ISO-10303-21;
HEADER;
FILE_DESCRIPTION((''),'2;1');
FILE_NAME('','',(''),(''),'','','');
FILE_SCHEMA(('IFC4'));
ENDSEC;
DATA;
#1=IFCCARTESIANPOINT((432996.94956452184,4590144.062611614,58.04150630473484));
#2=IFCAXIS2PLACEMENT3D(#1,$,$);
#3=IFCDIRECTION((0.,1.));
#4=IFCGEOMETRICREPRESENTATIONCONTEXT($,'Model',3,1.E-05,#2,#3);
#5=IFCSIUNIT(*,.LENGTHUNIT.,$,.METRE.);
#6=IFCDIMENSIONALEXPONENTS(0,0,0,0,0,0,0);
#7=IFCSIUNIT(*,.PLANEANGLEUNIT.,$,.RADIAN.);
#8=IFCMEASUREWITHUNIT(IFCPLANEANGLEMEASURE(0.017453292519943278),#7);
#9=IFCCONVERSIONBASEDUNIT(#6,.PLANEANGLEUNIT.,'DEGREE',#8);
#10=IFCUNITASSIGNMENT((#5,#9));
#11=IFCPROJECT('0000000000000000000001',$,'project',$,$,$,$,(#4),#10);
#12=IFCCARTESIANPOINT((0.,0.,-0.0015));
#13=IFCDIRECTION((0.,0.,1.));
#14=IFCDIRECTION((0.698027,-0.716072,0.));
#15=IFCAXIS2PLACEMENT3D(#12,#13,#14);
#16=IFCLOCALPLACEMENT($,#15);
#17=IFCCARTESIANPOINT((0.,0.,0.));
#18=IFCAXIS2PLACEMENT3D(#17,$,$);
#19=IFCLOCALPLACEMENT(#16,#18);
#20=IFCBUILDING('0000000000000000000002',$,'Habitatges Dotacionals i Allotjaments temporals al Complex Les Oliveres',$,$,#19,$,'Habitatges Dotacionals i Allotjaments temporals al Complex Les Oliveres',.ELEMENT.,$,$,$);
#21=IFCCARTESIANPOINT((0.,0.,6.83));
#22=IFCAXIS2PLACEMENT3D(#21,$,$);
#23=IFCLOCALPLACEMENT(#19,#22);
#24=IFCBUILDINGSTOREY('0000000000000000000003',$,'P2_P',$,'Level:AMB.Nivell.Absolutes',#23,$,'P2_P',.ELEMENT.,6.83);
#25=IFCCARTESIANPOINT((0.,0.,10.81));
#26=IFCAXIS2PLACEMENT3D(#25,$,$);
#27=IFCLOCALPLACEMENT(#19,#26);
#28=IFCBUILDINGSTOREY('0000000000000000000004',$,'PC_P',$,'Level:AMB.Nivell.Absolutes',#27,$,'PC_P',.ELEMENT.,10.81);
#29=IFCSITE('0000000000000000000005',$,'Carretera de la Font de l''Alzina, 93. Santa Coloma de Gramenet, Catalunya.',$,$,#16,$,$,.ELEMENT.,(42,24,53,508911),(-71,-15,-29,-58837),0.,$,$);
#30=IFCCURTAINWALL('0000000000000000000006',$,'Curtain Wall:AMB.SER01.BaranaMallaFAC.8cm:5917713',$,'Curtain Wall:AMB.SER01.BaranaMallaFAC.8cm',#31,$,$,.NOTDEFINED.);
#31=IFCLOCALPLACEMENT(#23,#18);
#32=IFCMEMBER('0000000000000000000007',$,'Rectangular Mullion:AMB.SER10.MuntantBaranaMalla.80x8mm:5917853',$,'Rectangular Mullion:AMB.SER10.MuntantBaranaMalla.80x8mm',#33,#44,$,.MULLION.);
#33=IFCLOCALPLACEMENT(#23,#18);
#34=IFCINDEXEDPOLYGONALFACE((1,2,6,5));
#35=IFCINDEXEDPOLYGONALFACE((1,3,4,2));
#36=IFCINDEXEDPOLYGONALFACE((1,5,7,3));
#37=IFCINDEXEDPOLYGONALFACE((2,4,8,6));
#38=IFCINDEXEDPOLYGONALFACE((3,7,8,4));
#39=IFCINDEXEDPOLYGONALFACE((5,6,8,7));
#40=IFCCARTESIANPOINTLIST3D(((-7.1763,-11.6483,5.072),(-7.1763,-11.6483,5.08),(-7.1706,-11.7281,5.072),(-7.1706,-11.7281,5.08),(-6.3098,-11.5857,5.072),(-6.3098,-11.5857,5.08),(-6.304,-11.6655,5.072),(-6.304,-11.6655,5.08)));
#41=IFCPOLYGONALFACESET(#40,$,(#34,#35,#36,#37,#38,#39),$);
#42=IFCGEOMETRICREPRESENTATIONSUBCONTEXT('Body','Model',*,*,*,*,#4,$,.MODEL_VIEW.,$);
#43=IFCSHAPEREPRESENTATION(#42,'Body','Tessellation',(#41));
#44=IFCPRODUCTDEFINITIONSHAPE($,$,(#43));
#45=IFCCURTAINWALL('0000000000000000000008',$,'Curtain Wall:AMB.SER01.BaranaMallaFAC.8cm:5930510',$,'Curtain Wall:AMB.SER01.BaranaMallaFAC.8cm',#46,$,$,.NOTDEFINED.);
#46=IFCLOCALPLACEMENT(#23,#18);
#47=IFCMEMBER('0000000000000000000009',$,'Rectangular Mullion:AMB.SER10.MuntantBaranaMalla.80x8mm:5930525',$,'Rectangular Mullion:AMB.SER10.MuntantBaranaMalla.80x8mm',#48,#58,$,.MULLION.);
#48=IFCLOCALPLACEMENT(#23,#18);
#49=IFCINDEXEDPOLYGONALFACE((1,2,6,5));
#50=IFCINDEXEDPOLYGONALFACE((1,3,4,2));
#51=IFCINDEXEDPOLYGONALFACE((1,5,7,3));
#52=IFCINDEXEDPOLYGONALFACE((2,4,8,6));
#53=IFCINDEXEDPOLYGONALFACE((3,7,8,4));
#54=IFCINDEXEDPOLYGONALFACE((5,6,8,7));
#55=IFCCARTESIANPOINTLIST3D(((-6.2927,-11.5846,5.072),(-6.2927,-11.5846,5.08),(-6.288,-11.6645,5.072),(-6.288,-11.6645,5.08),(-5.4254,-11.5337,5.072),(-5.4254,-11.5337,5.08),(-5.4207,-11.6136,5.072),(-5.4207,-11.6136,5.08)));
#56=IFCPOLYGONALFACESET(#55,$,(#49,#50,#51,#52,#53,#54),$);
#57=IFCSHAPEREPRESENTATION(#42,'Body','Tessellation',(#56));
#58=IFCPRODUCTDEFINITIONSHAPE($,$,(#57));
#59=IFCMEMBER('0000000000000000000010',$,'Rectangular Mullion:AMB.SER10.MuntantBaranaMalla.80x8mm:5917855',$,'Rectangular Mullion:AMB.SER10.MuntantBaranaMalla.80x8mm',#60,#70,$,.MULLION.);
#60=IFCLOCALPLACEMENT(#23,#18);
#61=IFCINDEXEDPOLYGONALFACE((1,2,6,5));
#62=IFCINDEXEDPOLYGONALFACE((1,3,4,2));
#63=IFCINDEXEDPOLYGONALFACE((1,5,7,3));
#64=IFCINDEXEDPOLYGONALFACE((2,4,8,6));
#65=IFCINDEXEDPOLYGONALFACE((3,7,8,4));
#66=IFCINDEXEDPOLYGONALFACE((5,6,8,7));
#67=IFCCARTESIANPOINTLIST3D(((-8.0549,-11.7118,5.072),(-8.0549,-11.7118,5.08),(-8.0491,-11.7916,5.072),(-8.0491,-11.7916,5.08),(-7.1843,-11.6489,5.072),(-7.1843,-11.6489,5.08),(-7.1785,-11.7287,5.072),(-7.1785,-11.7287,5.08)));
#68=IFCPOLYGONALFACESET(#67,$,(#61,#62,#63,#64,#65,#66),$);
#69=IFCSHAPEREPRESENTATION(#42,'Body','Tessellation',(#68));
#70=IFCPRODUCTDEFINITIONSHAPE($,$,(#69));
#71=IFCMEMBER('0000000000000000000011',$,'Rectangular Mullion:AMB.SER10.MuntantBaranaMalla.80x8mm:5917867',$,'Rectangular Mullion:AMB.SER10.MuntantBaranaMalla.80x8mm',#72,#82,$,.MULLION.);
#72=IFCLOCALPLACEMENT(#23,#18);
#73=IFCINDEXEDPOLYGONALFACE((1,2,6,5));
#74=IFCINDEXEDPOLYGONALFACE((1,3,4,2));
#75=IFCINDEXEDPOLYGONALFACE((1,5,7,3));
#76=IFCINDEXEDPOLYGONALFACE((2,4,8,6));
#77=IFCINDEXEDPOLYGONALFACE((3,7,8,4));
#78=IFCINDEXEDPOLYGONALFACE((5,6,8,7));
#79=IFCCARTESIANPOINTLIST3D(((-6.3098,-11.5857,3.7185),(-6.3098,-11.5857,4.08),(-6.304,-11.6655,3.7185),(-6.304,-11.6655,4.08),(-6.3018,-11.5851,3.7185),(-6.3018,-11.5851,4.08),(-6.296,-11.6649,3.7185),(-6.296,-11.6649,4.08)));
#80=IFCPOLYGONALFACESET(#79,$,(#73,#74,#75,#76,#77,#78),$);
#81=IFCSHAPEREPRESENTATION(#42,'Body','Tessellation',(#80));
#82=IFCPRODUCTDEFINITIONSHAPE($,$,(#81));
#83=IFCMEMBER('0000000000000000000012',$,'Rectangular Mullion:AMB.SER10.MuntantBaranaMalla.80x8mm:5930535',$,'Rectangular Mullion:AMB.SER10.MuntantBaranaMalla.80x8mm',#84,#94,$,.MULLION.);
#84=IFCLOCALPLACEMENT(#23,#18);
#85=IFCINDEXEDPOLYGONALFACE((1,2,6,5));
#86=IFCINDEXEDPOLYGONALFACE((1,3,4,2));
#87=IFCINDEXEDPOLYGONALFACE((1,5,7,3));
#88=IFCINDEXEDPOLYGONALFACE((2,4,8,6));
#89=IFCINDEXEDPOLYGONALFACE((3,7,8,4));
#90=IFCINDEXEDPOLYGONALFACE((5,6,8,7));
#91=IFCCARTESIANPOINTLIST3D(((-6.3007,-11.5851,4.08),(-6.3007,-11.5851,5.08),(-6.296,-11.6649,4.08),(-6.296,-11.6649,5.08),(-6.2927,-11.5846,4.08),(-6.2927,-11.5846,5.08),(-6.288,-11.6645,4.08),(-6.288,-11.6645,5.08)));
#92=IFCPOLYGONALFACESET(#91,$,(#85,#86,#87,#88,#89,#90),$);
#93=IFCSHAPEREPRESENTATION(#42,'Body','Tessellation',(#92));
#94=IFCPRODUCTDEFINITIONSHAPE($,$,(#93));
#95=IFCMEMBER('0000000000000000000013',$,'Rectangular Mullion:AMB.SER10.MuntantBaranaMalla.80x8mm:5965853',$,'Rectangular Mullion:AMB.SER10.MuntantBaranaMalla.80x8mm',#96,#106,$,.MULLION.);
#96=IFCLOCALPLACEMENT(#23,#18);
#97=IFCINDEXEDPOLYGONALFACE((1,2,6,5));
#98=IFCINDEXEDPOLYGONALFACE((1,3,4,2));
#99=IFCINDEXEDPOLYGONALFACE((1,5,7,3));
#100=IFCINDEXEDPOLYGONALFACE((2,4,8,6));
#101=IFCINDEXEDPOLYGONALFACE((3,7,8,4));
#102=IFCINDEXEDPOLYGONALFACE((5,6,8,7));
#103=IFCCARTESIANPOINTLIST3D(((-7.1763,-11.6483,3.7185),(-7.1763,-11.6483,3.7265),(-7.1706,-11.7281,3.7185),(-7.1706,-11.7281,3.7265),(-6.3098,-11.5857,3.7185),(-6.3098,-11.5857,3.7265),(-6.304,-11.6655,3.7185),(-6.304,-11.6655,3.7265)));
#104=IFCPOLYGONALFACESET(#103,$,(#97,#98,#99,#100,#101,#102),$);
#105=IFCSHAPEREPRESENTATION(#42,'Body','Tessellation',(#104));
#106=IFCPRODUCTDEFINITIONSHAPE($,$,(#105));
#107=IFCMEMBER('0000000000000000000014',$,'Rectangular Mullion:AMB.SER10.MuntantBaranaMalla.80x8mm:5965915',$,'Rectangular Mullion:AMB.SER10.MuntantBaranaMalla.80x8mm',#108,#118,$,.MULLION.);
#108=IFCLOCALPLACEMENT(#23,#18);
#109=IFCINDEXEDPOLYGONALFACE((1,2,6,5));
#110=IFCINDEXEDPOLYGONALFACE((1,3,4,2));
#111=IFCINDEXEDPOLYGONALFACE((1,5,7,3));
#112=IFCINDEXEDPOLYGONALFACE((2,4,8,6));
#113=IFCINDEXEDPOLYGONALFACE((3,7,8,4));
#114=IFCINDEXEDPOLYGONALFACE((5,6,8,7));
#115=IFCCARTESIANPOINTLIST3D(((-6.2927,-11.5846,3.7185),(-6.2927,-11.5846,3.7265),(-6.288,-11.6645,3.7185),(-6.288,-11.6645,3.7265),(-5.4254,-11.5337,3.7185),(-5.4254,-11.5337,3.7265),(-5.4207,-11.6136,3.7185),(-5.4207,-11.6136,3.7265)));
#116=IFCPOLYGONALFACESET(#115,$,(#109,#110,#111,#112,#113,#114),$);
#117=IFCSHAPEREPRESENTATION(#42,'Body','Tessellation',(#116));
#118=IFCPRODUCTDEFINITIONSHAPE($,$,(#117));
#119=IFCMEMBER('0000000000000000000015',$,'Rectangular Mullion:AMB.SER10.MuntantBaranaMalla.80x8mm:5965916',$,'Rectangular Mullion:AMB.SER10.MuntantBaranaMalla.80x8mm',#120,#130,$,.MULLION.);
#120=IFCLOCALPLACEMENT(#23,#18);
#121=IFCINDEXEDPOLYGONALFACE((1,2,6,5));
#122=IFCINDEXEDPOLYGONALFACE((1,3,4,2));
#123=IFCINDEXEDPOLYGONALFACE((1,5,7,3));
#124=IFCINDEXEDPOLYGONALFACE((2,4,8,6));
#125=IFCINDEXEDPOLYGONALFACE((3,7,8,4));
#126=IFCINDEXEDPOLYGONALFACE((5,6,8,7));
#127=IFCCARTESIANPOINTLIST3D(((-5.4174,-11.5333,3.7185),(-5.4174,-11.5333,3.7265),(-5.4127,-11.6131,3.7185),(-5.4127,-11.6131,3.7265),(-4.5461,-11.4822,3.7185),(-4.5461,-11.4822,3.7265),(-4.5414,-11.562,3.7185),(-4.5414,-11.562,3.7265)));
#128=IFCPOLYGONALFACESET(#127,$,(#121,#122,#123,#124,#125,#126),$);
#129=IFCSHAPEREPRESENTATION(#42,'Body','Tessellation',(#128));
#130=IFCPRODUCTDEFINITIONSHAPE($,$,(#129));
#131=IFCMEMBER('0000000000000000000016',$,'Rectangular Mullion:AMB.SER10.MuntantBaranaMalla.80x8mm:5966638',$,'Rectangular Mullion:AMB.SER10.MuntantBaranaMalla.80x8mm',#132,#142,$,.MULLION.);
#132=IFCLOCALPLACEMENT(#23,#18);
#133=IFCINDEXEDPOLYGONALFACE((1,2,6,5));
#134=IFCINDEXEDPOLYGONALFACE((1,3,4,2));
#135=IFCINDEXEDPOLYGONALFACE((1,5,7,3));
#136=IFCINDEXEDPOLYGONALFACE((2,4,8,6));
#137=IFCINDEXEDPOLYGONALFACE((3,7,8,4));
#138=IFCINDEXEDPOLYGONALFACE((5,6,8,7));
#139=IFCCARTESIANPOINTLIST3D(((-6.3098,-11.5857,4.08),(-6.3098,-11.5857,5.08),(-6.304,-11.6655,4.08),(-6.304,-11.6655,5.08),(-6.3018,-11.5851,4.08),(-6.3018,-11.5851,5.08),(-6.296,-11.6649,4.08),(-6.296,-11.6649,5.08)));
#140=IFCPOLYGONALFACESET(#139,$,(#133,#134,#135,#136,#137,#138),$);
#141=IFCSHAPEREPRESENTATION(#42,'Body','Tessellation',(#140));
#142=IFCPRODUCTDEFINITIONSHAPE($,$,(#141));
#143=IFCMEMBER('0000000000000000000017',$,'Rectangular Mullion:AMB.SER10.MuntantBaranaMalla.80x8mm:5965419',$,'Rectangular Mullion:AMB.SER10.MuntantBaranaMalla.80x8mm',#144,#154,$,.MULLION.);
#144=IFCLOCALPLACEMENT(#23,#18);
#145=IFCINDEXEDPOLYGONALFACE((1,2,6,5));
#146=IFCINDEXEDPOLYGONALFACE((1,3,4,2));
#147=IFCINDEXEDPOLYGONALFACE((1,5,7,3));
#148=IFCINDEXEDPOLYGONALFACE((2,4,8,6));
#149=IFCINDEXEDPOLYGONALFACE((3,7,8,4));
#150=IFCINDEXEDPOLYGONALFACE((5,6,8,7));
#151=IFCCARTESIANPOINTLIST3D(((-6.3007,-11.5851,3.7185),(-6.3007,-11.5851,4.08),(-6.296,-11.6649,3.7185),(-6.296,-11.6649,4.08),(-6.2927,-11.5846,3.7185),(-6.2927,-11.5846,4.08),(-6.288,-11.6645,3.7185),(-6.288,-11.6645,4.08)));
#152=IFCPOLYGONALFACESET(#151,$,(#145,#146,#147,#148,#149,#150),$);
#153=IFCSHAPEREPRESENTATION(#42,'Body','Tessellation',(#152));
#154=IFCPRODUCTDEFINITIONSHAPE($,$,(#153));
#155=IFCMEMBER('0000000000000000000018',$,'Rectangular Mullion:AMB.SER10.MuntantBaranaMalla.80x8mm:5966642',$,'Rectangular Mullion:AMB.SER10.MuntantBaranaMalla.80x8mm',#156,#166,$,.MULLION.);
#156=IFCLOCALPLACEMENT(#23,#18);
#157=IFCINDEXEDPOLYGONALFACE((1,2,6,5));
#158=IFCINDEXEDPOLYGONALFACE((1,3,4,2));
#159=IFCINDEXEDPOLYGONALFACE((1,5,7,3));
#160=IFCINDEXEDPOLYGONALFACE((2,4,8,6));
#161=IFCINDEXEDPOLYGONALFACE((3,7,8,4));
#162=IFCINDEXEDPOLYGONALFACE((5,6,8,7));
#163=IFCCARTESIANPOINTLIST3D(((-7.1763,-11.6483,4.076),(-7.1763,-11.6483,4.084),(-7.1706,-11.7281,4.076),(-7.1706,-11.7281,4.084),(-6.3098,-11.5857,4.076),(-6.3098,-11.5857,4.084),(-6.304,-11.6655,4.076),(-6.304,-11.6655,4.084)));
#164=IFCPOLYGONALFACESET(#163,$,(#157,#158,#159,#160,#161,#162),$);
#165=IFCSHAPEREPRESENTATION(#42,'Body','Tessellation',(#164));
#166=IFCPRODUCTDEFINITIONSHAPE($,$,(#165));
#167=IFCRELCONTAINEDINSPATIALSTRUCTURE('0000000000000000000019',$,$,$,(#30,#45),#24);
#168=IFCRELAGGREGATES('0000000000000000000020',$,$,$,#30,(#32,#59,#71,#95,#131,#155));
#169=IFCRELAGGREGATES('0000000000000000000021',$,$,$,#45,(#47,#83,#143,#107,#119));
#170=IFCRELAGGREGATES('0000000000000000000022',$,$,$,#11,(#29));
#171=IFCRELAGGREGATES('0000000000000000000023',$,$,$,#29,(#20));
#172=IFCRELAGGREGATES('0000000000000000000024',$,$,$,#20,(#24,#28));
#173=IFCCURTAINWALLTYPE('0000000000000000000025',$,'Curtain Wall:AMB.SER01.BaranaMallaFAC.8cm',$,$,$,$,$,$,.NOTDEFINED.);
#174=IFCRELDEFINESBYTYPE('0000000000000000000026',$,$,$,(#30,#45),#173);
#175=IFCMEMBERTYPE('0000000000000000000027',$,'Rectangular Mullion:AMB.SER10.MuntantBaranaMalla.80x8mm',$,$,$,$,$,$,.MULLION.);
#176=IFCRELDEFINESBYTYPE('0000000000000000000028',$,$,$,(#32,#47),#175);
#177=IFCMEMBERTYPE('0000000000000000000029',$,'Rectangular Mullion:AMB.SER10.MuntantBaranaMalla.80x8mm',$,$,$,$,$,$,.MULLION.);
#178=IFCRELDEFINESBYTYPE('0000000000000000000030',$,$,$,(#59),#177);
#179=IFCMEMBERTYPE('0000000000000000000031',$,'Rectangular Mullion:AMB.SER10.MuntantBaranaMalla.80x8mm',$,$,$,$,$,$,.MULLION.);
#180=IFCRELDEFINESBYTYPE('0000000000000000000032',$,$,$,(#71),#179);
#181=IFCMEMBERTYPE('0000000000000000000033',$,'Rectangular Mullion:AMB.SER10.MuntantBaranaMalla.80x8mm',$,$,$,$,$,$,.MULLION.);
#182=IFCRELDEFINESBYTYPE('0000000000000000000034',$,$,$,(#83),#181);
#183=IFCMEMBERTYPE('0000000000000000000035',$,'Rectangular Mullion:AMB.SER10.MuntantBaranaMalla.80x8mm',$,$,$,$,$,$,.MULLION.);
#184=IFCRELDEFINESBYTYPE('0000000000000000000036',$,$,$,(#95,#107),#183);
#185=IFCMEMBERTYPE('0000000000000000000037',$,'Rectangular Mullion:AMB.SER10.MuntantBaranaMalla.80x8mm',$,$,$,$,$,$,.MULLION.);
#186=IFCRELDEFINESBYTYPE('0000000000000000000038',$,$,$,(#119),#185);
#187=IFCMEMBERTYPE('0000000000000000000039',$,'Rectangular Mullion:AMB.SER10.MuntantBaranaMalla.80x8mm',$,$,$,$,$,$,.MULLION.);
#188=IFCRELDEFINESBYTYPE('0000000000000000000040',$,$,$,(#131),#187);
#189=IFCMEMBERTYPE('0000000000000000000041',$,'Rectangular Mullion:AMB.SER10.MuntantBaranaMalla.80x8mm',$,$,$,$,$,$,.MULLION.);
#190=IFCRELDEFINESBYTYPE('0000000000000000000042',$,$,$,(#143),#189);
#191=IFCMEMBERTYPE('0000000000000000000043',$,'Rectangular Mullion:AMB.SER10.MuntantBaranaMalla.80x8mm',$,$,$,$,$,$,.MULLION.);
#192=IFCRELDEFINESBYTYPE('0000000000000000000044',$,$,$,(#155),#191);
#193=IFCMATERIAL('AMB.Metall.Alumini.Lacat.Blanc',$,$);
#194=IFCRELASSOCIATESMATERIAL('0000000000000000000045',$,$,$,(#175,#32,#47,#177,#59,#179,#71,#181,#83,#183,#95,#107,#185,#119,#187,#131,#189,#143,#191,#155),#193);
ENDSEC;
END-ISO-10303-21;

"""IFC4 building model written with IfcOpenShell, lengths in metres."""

from ifc_helpers import new_model, entity, si_unit, converted_unit, direction, frame, origin, place, context, subcontext, project, spatial, indexed_curve, outline, extrude, source, transform, mapped, material, type_object, type_shapes, element, aggregate, save


model = new_model("IFC4")

# Units and contexts
model_context = context("Model", 3, precision=1e-05, world=frame((432996.94956452184, 4590144.062611614, 58.04150630473484)), true_north=direction((0.0, 1.0)))
body_context = subcontext(model_context, "Body", "Model", "MODEL_VIEW")
ifc_project = project(units=[si_unit("LENGTHUNIT", "METRE"), converted_unit("PLANEANGLEUNIT", "DEGREE", entity("IfcPlaneAngleMeasure", 0.017453292519943278), si_unit("PLANEANGLEUNIT", "RADIAN"), dimensions=[0, 0, 0, 0, 0, 0, 0])], contexts=[model_context])

# Site, building, storey
site_placement = place(None, frame((0.0, 0.0, -0.0015), z_axis=(0.0, 0.0, 1.0), x_axis=(0.698027, -0.716072, 0.0)))
site = spatial("IfcSite", under=ifc_project, at=site_placement, Name="Carretera de la Font de l'Alzina, 93. Santa Coloma de Gramenet, Catalunya.", CompositionType="ELEMENT", RefLatitude=(42, 24, 53, 508911), RefLongitude=(-71, -15, -29, -58837), RefElevation=0.0)
building_placement = place(site_placement, origin())
building = spatial("IfcBuilding", under=site, at=building_placement, Name="Habitatges Dotacionals i Allotjaments temporals al Complex Les Oliveres", LongName="Habitatges Dotacionals i Allotjaments temporals al Complex Les Oliveres", CompositionType="ELEMENT")
storey_1_placement = place(building_placement, frame((0.0, 0.0, 6.83)))
storey_1 = spatial("IfcBuildingStorey", under=building, at=storey_1_placement, Name="P2_P", ObjectType="Level:AMB.Nivell.Absolutes", LongName="P2_P", CompositionType="ELEMENT", Elevation=6.83)

# Curtain walls, members
curtain_wall_type = type_object("IfcCurtainWallType", Name="Curtain Wall:AMB.SER01.BaranaMallaFAC.8cm", PredefinedType="NOTDEFINED")
curtain_wall_1_placement = place(storey_1_placement, frame((0.0, 0.0, -6.83)))
curtain_wall_1 = element("IfcCurtainWall", 1, at=curtain_wall_1_placement, inside=storey_1, type_object=curtain_wall_type, Name="Curtain Wall:AMB.SER01.BaranaMallaFAC.8cm:5917713", ObjectType="Curtain Wall:AMB.SER01.BaranaMallaFAC.8cm", PredefinedType="NOTDEFINED")
ifc_material_1 = material(Name="AMB.Metall.Alumini.Lacat.Blanc")
member_type_1 = type_object("IfcMemberType", Name="Rectangular Mullion:AMB.SER10.MuntantBaranaMalla.80x8mm", PredefinedType="MULLION", material=ifc_material_1)
shared_shape_1 = source(origin(), body_context, "Body", "SweptSolid", [
    extrude(outline(indexed_curve([(-0.004, -0.04), (0.004, -0.04), (0.004, 0.04), (-0.004, 0.04), (-0.004, -0.04)], self_intersect=False)), frame((-0.004, -0.04, -0.8688), z_axis=(0.0, 0.0, 1.0), x_axis=(-1.0, 0.0, 0.0)), (0.0, 0.0, 1.0), 0.8688),
])
type_shapes(member_type_1, [shared_shape_1])
member_1_placement = place(curtain_wall_1_placement, frame((-6.304, -11.6655, 11.91), z_axis=(0.9974, 0.072068, 0.0), x_axis=(0.0, 0.0, 1.0)))
member_1 = element("IfcMember", 2, at=member_1_placement, type_object=member_type_1, material=ifc_material_1, Name="Rectangular Mullion:AMB.SER10.MuntantBaranaMalla.80x8mm:5917853", ObjectType="Rectangular Mullion:AMB.SER10.MuntantBaranaMalla.80x8mm", PredefinedType="MULLION", context=body_context, shape_type="MappedRepresentation", body=[
    mapped(shared_shape_1, transform((0.0, 0.0, 0.0), scale=1.0)),
])
curtain_wall_2_placement = place(storey_1_placement, frame((0.0, 0.0, -6.83)))
curtain_wall_2 = element("IfcCurtainWall", 3, at=curtain_wall_2_placement, inside=storey_1, type_object=curtain_wall_type, Name="Curtain Wall:AMB.SER01.BaranaMallaFAC.8cm:5930510", ObjectType="Curtain Wall:AMB.SER01.BaranaMallaFAC.8cm", PredefinedType="NOTDEFINED")
member_2_placement = place(curtain_wall_2_placement, frame((-5.4207, -11.6136, 11.91), z_axis=(0.998284, 0.058552, 0.0), x_axis=(0.0, 0.0, 1.0)))
member_2 = element("IfcMember", 4, at=member_2_placement, type_object=member_type_1, material=ifc_material_1, Name="Rectangular Mullion:AMB.SER10.MuntantBaranaMalla.80x8mm:5930525", ObjectType="Rectangular Mullion:AMB.SER10.MuntantBaranaMalla.80x8mm", PredefinedType="MULLION", context=body_context, shape_type="MappedRepresentation", body=[
    mapped(shared_shape_1, transform((0.0, 0.0, 0.0), scale=1.0)),
])

# Members
member_type_2 = type_object("IfcMemberType", Name="Rectangular Mullion:AMB.SER10.MuntantBaranaMalla.80x8mm", PredefinedType="MULLION", material=ifc_material_1)
shared_shape_2 = source(origin(), body_context, "Body", "SweptSolid", [
    extrude(outline(indexed_curve([(-0.004, -0.04), (0.004, -0.04), (0.004, 0.04), (-0.004, 0.04), (-0.004, -0.04)], self_intersect=False)), frame((-0.004, -0.04, -0.8728), z_axis=(0.0, 0.0, 1.0), x_axis=(-1.0, 0.0, 0.0)), (0.0, 0.0, 1.0), 0.8728),
])
type_shapes(member_type_2, [shared_shape_2])
member_3_placement = place(curtain_wall_1_placement, frame((-7.1785, -11.7287, 11.91), z_axis=(0.9974, 0.072068, 0.0), x_axis=(0.0, 0.0, 1.0)))
member_3 = element("IfcMember", 5, at=member_3_placement, type_object=member_type_2, material=ifc_material_1, Name="Rectangular Mullion:AMB.SER10.MuntantBaranaMalla.80x8mm:5917855", ObjectType="Rectangular Mullion:AMB.SER10.MuntantBaranaMalla.80x8mm", PredefinedType="MULLION", context=body_context, shape_type="MappedRepresentation", body=[
    mapped(shared_shape_2, transform((0.0, 0.0, 0.0), scale=1.0)),
])
member_type_3 = type_object("IfcMemberType", Name="Rectangular Mullion:AMB.SER10.MuntantBaranaMalla.80x8mm", PredefinedType="MULLION", material=ifc_material_1)
shared_shape_3 = source(origin(), body_context, "Body", "SweptSolid", [
    extrude(outline(indexed_curve([(-0.004, -0.04), (0.004, -0.04), (0.004, 0.04), (-0.004, 0.04), (-0.004, -0.04)], self_intersect=False)), frame((-0.004, -0.04, -0.3615), z_axis=(0.0, 0.0, 1.0), x_axis=(-1.0, 0.0, 0.0)), (0.0, 0.0, 1.0), 0.3615),
])
type_shapes(member_type_3, [shared_shape_3])
member_4_placement = place(curtain_wall_1_placement, frame((-6.296, -11.6649, 10.5485), z_axis=(0.0, 0.0, -1.0), x_axis=(0.9974, 0.072068, 0.0)))
member_4 = element("IfcMember", 6, at=member_4_placement, type_object=member_type_3, material=ifc_material_1, Name="Rectangular Mullion:AMB.SER10.MuntantBaranaMalla.80x8mm:5917867", ObjectType="Rectangular Mullion:AMB.SER10.MuntantBaranaMalla.80x8mm", PredefinedType="MULLION", context=body_context, shape_type="MappedRepresentation", body=[
    mapped(shared_shape_3, transform((0.0, 0.0, 0.0), scale=1.0)),
])
member_type_4 = type_object("IfcMemberType", Name="Rectangular Mullion:AMB.SER10.MuntantBaranaMalla.80x8mm", PredefinedType="MULLION", material=ifc_material_1)
shared_shape_4 = source(origin(), body_context, "Body", "SweptSolid", [
    extrude(outline(indexed_curve([(-0.004, -0.04), (0.004, -0.04), (0.004, 0.04), (-0.004, 0.04), (-0.004, -0.04)], self_intersect=False)), frame((-0.004, -0.04, -1.0), z_axis=(0.0, 0.0, 1.0), x_axis=(-1.0, 0.0, 0.0)), (0.0, 0.0, 1.0), 1.0),
])
type_shapes(member_type_4, [shared_shape_4])
member_5_placement = place(curtain_wall_2_placement, frame((-6.296, -11.6649, 11.91), z_axis=(0.0, 0.0, 1.0), x_axis=(-0.998284, -0.058552, 0.0)))
member_5 = element("IfcMember", 7, at=member_5_placement, type_object=member_type_4, material=ifc_material_1, Name="Rectangular Mullion:AMB.SER10.MuntantBaranaMalla.80x8mm:5930535", ObjectType="Rectangular Mullion:AMB.SER10.MuntantBaranaMalla.80x8mm", PredefinedType="MULLION", context=body_context, shape_type="MappedRepresentation", body=[
    mapped(shared_shape_4, transform((0.0, 0.0, 0.0), scale=1.0)),
])
member_type_5 = type_object("IfcMemberType", Name="Rectangular Mullion:AMB.SER10.MuntantBaranaMalla.80x8mm", PredefinedType="MULLION", material=ifc_material_1)
shared_shape_5 = source(origin(), body_context, "Body", "SweptSolid", [
    extrude(outline(indexed_curve([(-0.004, -0.04), (0.004, -0.04), (0.004, 0.04), (-0.004, 0.04), (-0.004, -0.04)], self_intersect=False)), frame((-0.004, -0.04, -0.8688), z_axis=(0.0, 0.0, 1.0), x_axis=(-1.0, 0.0, 0.0)), (0.0, 0.0, 1.0), 0.8688),
])
type_shapes(member_type_5, [shared_shape_5])
member_6_placement = place(curtain_wall_1_placement, frame((-7.1706, -11.7281, 10.5485), z_axis=(-0.9974, -0.072068, 0.0), x_axis=(0.0, 0.0, -1.0)))
member_6 = element("IfcMember", 8, at=member_6_placement, type_object=member_type_5, material=ifc_material_1, Name="Rectangular Mullion:AMB.SER10.MuntantBaranaMalla.80x8mm:5965853", ObjectType="Rectangular Mullion:AMB.SER10.MuntantBaranaMalla.80x8mm", PredefinedType="MULLION", context=body_context, shape_type="MappedRepresentation", body=[
    mapped(shared_shape_5, transform((0.0, 0.0, 0.0), scale=1.0)),
])
member_7_placement = place(curtain_wall_2_placement, frame((-6.288, -11.6645, 10.5485), z_axis=(-0.998284, -0.058552, 0.0), x_axis=(0.0, 0.0, -1.0)))
member_7 = element("IfcMember", 9, at=member_7_placement, type_object=member_type_5, material=ifc_material_1, Name="Rectangular Mullion:AMB.SER10.MuntantBaranaMalla.80x8mm:5965915", ObjectType="Rectangular Mullion:AMB.SER10.MuntantBaranaMalla.80x8mm", PredefinedType="MULLION", context=body_context, shape_type="MappedRepresentation", body=[
    mapped(shared_shape_5, transform((0.0, 0.0, 0.0), scale=1.0)),
])
member_type_6 = type_object("IfcMemberType", Name="Rectangular Mullion:AMB.SER10.MuntantBaranaMalla.80x8mm", PredefinedType="MULLION", material=ifc_material_1)
shared_shape_6 = source(origin(), body_context, "Body", "SweptSolid", [
    extrude(outline(indexed_curve([(-0.004, -0.04), (0.004, -0.04), (0.004, 0.04), (-0.004, 0.04), (-0.004, -0.04)], self_intersect=False)), frame((-0.004, -0.04, -0.8728), z_axis=(0.0, 0.0, 1.0), x_axis=(-1.0, 0.0, 0.0)), (0.0, 0.0, 1.0), 0.8728),
])
type_shapes(member_type_6, [shared_shape_6])
member_8_placement = place(curtain_wall_2_placement, frame((-5.4127, -11.6131, 10.5485), z_axis=(-0.998284, -0.058552, 0.0), x_axis=(0.0, 0.0, -1.0)))
member_8 = element("IfcMember", 10, at=member_8_placement, type_object=member_type_6, material=ifc_material_1, Name="Rectangular Mullion:AMB.SER10.MuntantBaranaMalla.80x8mm:5965916", ObjectType="Rectangular Mullion:AMB.SER10.MuntantBaranaMalla.80x8mm", PredefinedType="MULLION", context=body_context, shape_type="MappedRepresentation", body=[
    mapped(shared_shape_6, transform((0.0, 0.0, 0.0), scale=1.0)),
])
member_type_7 = type_object("IfcMemberType", Name="Rectangular Mullion:AMB.SER10.MuntantBaranaMalla.80x8mm", PredefinedType="MULLION", material=ifc_material_1)
shared_shape_7 = source(origin(), body_context, "Body", "SweptSolid", [
    extrude(outline(indexed_curve([(-0.004, -0.04), (0.004, -0.04), (0.004, 0.04), (-0.004, 0.04), (-0.004, -0.04)], self_intersect=False)), frame((-0.004, -0.04, -1.0), z_axis=(0.0, 0.0, 1.0), x_axis=(-1.0, 0.0, 0.0)), (0.0, 0.0, 1.0), 1.0),
])
type_shapes(member_type_7, [shared_shape_7])
member_9_placement = place(curtain_wall_1_placement, frame((-6.296, -11.6649, 10.91), z_axis=(0.0, 0.0, -1.0), x_axis=(0.9974, 0.072068, 0.0)))
member_9 = element("IfcMember", 11, at=member_9_placement, type_object=member_type_7, material=ifc_material_1, Name="Rectangular Mullion:AMB.SER10.MuntantBaranaMalla.80x8mm:5966638", ObjectType="Rectangular Mullion:AMB.SER10.MuntantBaranaMalla.80x8mm", PredefinedType="MULLION", context=body_context, shape_type="MappedRepresentation", body=[
    mapped(shared_shape_7, transform((0.0, 0.0, 0.0), scale=1.0)),
])
member_type_8 = type_object("IfcMemberType", Name="Rectangular Mullion:AMB.SER10.MuntantBaranaMalla.80x8mm", PredefinedType="MULLION", material=ifc_material_1)
shared_shape_8 = source(origin(), body_context, "Body", "SweptSolid", [
    extrude(outline(indexed_curve([(-0.004, -0.04), (0.004, -0.04), (0.004, 0.04), (-0.004, 0.04), (-0.004, -0.04)], self_intersect=False)), frame((-0.004, -0.04, -0.3615), z_axis=(0.0, 0.0, 1.0), x_axis=(-1.0, 0.0, 0.0)), (0.0, 0.0, 1.0), 0.3615),
])
type_shapes(member_type_8, [shared_shape_8])
member_10_placement = place(curtain_wall_2_placement, frame((-6.296, -11.6649, 10.91), z_axis=(0.0, 0.0, 1.0), x_axis=(-0.998284, -0.058552, 0.0)))
member_10 = element("IfcMember", 12, at=member_10_placement, type_object=member_type_8, material=ifc_material_1, Name="Rectangular Mullion:AMB.SER10.MuntantBaranaMalla.80x8mm:5965419", ObjectType="Rectangular Mullion:AMB.SER10.MuntantBaranaMalla.80x8mm", PredefinedType="MULLION", context=body_context, shape_type="MappedRepresentation", body=[
    mapped(shared_shape_8, transform((0.0, 0.0, 0.0), scale=1.0)),
])
member_type_9 = type_object("IfcMemberType", Name="Rectangular Mullion:AMB.SER10.MuntantBaranaMalla.80x8mm", PredefinedType="MULLION", material=ifc_material_1)
shared_shape_9 = source(origin(), body_context, "Body", "SweptSolid", [
    extrude(outline(indexed_curve([(-0.004, -0.04), (0.004, -0.04), (0.004, 0.04), (-0.004, 0.04), (-0.004, -0.04)], self_intersect=False)), frame((0.0, -0.04, -0.8688), z_axis=(0.0, 0.0, 1.0), x_axis=(-1.0, 0.0, 0.0)), (0.0, 0.0, 1.0), 0.8688),
])
type_shapes(member_type_9, [shared_shape_9])
member_11_placement = place(curtain_wall_1_placement, frame((-6.304, -11.6655, 10.91), z_axis=(0.9974, 0.072068, 0.0), x_axis=(0.0, 0.0, 1.0)))
member_11 = element("IfcMember", 13, at=member_11_placement, type_object=member_type_9, material=ifc_material_1, Name="Rectangular Mullion:AMB.SER10.MuntantBaranaMalla.80x8mm:5966642", ObjectType="Rectangular Mullion:AMB.SER10.MuntantBaranaMalla.80x8mm", PredefinedType="MULLION", context=body_context, shape_type="MappedRepresentation", body=[
    mapped(shared_shape_9, transform((0.0, 0.0, 0.0), scale=1.0)),
])

aggregate(curtain_wall_1, [member_1, member_3, member_4, member_6, member_9, member_11])
aggregate(curtain_wall_2, [member_2, member_5, member_10, member_7, member_8])

# Shared definitions
storey_2_placement = place(building_placement, frame((0.0, 0.0, 10.81)))
storey_2 = spatial("IfcBuildingStorey", under=building, at=storey_2_placement, Name="PC_P", ObjectType="Level:AMB.Nivell.Absolutes", LongName="PC_P", CompositionType="ELEMENT", Elevation=10.81)

save(model, "model.ifc")
